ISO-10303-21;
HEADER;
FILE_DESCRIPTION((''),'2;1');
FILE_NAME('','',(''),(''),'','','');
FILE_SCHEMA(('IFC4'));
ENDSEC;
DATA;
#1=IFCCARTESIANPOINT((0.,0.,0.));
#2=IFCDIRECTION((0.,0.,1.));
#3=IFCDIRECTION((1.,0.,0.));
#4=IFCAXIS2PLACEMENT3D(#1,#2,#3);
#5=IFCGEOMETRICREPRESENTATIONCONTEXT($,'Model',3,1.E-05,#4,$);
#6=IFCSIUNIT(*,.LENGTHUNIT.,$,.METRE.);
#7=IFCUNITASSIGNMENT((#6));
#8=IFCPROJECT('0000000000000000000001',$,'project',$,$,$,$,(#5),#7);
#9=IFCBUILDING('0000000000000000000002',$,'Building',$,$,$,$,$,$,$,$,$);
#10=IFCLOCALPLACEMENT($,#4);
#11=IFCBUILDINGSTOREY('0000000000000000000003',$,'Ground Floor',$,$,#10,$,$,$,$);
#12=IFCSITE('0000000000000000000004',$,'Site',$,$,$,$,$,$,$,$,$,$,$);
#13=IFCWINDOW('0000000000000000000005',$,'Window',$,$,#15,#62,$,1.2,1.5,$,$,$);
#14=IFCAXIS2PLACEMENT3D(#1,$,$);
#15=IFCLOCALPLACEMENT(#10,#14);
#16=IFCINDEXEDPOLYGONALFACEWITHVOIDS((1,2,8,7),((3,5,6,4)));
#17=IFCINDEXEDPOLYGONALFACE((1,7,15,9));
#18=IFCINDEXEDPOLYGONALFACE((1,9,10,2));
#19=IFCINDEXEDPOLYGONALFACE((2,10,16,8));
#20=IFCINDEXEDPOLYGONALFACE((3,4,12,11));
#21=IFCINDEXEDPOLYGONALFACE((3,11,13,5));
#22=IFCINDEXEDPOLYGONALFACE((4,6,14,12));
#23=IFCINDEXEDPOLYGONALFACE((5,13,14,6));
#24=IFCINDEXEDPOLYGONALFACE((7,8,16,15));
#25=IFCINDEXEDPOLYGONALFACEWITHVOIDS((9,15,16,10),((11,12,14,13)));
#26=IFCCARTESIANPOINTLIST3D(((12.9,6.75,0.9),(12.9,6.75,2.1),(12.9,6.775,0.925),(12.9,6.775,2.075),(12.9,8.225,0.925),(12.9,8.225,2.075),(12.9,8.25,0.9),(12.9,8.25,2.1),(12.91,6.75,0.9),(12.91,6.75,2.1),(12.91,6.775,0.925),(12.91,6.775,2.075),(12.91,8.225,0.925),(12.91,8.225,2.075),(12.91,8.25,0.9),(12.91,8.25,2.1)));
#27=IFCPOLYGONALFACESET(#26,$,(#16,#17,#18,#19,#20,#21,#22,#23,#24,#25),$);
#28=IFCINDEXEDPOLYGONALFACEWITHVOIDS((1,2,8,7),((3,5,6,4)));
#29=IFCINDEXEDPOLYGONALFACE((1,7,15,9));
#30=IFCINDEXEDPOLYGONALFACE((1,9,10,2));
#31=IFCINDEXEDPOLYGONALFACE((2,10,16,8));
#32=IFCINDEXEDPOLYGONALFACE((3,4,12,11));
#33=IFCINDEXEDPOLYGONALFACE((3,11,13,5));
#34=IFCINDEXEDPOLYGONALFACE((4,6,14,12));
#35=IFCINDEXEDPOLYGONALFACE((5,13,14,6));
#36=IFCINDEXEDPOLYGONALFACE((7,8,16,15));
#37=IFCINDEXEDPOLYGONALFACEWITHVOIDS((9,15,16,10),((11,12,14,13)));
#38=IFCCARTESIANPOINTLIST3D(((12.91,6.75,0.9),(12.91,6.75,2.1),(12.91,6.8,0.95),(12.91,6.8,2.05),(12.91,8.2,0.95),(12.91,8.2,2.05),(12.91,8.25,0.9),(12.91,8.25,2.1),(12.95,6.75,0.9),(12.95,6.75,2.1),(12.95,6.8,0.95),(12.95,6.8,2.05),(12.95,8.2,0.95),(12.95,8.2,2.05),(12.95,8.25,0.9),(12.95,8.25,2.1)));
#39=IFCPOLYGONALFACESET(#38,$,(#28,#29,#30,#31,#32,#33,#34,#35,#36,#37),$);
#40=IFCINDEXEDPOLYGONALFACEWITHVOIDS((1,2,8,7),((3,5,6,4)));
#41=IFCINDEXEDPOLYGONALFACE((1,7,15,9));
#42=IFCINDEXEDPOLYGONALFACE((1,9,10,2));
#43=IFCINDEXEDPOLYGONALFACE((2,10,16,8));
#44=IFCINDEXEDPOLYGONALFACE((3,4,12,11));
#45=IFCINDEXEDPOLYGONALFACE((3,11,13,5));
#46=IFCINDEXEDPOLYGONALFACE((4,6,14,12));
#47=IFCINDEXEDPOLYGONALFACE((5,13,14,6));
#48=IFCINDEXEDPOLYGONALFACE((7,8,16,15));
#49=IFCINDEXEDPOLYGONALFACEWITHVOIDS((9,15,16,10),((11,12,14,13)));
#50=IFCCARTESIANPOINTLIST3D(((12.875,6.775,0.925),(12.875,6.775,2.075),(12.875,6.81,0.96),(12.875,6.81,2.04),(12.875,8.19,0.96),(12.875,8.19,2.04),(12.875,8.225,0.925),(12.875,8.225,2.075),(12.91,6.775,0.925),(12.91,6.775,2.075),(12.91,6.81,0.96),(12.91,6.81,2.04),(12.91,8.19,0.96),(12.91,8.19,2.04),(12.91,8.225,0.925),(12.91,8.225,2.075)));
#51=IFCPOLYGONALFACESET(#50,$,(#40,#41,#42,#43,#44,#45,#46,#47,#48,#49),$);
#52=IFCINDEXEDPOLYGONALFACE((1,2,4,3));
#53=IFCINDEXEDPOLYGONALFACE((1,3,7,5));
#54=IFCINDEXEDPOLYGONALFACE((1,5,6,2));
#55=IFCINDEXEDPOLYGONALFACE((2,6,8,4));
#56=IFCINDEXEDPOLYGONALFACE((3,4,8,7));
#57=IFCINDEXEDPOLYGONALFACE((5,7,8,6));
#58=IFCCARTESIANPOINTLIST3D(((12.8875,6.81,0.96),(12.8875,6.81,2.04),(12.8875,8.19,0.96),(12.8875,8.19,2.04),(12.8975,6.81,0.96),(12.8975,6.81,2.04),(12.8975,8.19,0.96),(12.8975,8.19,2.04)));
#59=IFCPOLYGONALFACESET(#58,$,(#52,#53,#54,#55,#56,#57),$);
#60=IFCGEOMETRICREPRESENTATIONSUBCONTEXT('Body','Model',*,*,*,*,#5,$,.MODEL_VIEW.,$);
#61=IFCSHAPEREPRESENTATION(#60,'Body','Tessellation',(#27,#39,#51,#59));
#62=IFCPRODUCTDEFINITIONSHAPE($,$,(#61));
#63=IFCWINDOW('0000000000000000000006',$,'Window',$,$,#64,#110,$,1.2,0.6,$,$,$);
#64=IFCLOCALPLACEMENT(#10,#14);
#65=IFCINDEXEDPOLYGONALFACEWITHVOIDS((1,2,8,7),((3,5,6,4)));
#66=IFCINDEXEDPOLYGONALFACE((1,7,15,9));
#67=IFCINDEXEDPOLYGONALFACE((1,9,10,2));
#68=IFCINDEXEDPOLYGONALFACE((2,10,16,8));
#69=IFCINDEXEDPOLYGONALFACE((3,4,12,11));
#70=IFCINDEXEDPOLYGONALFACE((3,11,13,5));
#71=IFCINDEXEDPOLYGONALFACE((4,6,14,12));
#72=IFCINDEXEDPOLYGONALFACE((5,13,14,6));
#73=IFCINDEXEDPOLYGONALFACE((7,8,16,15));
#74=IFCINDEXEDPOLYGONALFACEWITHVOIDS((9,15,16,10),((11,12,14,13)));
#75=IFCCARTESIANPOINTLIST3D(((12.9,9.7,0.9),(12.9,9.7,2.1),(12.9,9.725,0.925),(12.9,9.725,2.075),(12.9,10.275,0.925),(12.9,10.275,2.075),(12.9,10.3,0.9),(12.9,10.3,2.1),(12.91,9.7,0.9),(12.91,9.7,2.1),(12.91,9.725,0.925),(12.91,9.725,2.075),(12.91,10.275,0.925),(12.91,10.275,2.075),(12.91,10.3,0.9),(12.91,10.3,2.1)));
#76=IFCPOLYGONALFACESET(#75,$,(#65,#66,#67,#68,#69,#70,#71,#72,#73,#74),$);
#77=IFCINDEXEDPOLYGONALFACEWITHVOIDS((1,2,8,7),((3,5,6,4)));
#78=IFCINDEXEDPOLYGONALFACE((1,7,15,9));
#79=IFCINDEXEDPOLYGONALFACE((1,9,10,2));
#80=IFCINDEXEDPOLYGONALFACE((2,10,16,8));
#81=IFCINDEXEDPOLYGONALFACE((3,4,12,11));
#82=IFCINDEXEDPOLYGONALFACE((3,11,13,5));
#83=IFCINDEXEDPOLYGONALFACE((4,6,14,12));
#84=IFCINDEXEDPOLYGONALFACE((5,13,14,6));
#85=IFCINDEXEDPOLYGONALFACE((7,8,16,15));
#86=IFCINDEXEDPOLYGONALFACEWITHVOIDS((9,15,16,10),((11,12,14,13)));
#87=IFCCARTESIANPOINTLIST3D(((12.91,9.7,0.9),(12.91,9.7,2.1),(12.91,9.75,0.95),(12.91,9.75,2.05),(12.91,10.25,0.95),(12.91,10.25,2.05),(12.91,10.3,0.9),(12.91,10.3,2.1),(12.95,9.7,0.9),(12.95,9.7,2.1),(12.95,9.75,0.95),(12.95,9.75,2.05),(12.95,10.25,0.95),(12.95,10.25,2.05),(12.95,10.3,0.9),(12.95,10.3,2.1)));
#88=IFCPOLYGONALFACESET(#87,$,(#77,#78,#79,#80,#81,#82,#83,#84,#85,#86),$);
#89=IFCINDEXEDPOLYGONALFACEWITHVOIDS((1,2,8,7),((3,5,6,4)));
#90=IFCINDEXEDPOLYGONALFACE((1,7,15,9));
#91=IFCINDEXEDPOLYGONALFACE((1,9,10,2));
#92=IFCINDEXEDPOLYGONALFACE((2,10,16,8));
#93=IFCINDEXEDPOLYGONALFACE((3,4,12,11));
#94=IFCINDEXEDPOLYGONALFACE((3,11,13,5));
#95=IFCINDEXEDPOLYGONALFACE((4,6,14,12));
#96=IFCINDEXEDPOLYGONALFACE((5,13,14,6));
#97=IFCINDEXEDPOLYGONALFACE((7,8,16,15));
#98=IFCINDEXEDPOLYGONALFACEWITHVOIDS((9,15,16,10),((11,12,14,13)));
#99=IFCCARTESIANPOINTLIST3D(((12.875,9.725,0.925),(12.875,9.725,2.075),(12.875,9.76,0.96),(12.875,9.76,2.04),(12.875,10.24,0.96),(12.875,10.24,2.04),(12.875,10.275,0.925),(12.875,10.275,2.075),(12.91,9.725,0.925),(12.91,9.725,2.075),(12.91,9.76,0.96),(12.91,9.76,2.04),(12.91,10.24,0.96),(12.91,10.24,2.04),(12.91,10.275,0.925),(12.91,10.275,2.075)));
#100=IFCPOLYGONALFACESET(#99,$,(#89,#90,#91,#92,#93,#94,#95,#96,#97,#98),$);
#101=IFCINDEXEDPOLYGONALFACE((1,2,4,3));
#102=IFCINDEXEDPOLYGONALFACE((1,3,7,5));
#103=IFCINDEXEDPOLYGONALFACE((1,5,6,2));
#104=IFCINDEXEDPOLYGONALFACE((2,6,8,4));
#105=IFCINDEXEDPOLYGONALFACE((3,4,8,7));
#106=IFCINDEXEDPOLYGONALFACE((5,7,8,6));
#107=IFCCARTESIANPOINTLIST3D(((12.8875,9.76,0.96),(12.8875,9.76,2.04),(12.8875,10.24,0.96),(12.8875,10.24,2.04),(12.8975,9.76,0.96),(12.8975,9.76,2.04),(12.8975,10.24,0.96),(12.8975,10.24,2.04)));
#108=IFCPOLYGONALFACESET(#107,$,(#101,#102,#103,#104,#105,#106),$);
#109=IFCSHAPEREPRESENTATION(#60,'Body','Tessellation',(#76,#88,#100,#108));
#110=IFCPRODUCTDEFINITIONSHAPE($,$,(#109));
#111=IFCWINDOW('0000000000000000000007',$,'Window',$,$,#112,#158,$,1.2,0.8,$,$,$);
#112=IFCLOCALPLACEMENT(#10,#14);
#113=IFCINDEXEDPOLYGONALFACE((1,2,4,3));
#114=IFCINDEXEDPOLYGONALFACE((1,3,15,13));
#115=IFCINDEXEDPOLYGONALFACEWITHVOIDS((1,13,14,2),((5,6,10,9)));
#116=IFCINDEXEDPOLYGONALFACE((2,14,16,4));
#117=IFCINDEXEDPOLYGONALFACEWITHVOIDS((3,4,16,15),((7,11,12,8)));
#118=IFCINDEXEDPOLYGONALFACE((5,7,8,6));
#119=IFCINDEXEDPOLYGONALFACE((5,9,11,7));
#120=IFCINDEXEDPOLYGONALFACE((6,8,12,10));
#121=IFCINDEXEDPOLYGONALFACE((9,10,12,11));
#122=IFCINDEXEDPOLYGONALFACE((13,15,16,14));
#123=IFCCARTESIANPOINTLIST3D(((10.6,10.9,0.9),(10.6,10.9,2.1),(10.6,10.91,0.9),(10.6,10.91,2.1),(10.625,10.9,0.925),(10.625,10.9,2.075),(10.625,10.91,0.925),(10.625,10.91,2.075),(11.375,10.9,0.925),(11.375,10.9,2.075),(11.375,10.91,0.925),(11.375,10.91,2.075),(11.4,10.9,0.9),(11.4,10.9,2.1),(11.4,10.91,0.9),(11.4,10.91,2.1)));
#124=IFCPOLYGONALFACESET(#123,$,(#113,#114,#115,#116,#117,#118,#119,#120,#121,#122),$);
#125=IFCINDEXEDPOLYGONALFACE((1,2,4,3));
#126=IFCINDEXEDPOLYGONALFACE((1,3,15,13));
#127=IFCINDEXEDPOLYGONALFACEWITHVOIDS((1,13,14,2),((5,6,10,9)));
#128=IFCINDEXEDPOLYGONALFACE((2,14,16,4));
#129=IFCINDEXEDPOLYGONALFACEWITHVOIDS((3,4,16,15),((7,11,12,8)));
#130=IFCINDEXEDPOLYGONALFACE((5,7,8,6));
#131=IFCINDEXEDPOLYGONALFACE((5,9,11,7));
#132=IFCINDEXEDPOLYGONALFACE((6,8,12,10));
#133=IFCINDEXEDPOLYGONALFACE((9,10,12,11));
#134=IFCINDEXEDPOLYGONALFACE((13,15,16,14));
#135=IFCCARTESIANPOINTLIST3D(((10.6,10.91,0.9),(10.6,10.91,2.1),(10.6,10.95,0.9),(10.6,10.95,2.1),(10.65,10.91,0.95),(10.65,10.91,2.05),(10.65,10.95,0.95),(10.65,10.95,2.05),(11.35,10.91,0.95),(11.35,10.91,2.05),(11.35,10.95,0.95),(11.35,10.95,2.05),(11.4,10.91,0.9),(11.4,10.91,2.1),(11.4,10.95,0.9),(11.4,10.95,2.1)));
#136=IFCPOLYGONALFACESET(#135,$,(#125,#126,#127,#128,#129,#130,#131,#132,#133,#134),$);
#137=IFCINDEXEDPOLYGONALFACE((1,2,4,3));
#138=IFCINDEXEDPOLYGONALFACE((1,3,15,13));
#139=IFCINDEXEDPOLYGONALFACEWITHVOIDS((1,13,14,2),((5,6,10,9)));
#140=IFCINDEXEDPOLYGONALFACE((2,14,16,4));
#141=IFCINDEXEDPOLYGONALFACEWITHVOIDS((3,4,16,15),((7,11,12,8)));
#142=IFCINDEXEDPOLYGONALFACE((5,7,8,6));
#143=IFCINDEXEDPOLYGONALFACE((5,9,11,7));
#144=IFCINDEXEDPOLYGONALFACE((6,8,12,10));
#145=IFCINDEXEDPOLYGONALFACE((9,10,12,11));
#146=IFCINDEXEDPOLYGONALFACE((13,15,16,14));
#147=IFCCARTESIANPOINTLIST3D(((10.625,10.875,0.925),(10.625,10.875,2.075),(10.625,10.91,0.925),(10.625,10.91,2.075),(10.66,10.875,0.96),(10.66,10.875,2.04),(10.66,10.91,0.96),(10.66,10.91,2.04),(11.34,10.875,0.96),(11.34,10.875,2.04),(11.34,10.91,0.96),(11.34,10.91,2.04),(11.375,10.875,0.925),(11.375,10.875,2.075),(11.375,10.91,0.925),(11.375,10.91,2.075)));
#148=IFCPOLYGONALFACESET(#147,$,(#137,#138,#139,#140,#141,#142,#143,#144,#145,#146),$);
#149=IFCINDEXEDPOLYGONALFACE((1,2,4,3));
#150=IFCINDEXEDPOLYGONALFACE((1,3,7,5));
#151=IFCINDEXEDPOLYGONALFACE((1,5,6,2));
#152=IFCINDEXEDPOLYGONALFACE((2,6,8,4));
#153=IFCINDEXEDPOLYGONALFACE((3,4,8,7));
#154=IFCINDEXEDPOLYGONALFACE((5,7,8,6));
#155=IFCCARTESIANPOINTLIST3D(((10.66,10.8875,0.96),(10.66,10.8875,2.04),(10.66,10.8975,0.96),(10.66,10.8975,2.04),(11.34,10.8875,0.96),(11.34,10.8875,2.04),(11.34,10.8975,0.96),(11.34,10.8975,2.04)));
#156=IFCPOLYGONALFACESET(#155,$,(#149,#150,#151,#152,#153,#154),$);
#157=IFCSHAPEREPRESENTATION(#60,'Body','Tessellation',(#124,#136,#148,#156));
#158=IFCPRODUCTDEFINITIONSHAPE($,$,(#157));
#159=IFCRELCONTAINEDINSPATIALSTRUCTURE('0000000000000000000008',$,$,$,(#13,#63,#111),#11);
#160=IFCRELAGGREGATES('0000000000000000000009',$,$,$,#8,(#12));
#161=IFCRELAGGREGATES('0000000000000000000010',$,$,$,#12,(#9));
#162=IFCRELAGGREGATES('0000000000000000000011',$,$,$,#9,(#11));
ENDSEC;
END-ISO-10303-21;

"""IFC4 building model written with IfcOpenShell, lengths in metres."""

from ifc_helpers import new_model, si_unit, frame, origin_with_axes, place, context, subcontext, project, spatial, line, indexed_curve, outline, extrude, element, save


model = new_model("IFC4")

# Units and contexts
model_context = context("Model", 3, precision=1e-05, world=origin_with_axes())
body_context = subcontext(model_context, "Body", "Model", "MODEL_VIEW")
ifc_project = project(units=[si_unit("LENGTHUNIT", "METRE")], contexts=[model_context])

# Site, building, storey
site = spatial("IfcSite", under=ifc_project, Name="Site")
building = spatial("IfcBuilding", under=site, Name="Building")
storey_placement = place(None, origin_with_axes())
storey = spatial("IfcBuildingStorey", under=building, at=storey_placement, Name="Ground Floor")

# Windows
window_1_placement = place(storey_placement, frame((13.0, 6.75, 0.9), z_axis=(0.0, 0.0, 1.0), x_axis=(0.0, 1.0, 0.0)))
element("IfcWindow", 1, at=window_1_placement, inside=storey, Name="Window", OverallHeight=1.2, OverallWidth=1.5, context=body_context, shape_type="SweptSolid", body=[
    extrude(outline(indexed_curve([(0.0, 0.0), (1.5, 0.0), (1.5, 1.2), (0.0, 1.2)], segments=[line(1, 2, 3, 4, 1)]), holes=[indexed_curve([(0.025, 0.025), (1.475, 0.025), (1.475, 1.175), (0.025, 1.175)], segments=[line(1, 2, 3, 4, 1)])]), frame((0.0, 0.09, 0.0), z_axis=(0.0, -1.0, 0.0), x_axis=(1.0, 0.0, 0.0)), (0.0, 0.0, -1.0), 0.01),
    extrude(outline(indexed_curve([(0.0, 0.0), (1.5, 0.0), (1.5, 1.2), (0.0, 1.2)], segments=[line(1, 2, 3, 4, 1)]), holes=[indexed_curve([(0.05, 0.05), (1.45, 0.05), (1.45, 1.15), (0.05, 1.15)], segments=[line(1, 2, 3, 4, 1)])]), frame((0.0, 0.05, 0.0), z_axis=(0.0, -1.0, 0.0), x_axis=(1.0, 0.0, 0.0)), (0.0, 0.0, -1.0), 0.04),
    extrude(outline(indexed_curve([(0.0, 0.0), (1.45, 0.0), (1.45, 1.15), (0.0, 1.15)], segments=[line(1, 2, 3, 4, 1)]), holes=[indexed_curve([(0.035, 0.035), (1.415, 0.035), (1.415, 1.115), (0.035, 1.115)], segments=[line(1, 2, 3, 4, 1)])]), frame((0.025, 0.09, 0.025), z_axis=(0.0, -1.0, 0.0), x_axis=(1.0, 0.0, 0.0)), (0.0, 0.0, -1.0), 0.035),
    extrude(outline(indexed_curve([(0.035, 0.035), (1.415, 0.035), (1.415, 1.115), (0.035, 1.115)], segments=[line(1, 2, 3, 4, 1)])), frame((0.025, 0.1025, 0.025), z_axis=(0.0, -1.0, 0.0), x_axis=(1.0, 0.0, 0.0)), (0.0, 0.0, -1.0), 0.01),
])
window_2_placement = place(storey_placement, frame((13.0, 9.7, 0.9), z_axis=(0.0, 0.0, 1.0), x_axis=(0.0, 1.0, 0.0)))
element("IfcWindow", 2, at=window_2_placement, inside=storey, Name="Window", OverallHeight=1.2, OverallWidth=0.6, context=body_context, shape_type="SweptSolid", body=[
    extrude(outline(indexed_curve([(0.0, 0.0), (0.6, 0.0), (0.6, 1.2), (0.0, 1.2)], segments=[line(1, 2, 3, 4, 1)]), holes=[indexed_curve([(0.025, 0.025), (0.575, 0.025), (0.575, 1.175), (0.025, 1.175)], segments=[line(1, 2, 3, 4, 1)])]), frame((0.0, 0.09, 0.0), z_axis=(0.0, -1.0, 0.0), x_axis=(1.0, 0.0, 0.0)), (0.0, 0.0, -1.0), 0.01),
    extrude(outline(indexed_curve([(0.0, 0.0), (0.6, 0.0), (0.6, 1.2), (0.0, 1.2)], segments=[line(1, 2, 3, 4, 1)]), holes=[indexed_curve([(0.05, 0.05), (0.55, 0.05), (0.55, 1.15), (0.05, 1.15)], segments=[line(1, 2, 3, 4, 1)])]), frame((0.0, 0.05, 0.0), z_axis=(0.0, -1.0, 0.0), x_axis=(1.0, 0.0, 0.0)), (0.0, 0.0, -1.0), 0.04),
    extrude(outline(indexed_curve([(0.0, 0.0), (0.55, 0.0), (0.55, 1.15), (0.0, 1.15)], segments=[line(1, 2, 3, 4, 1)]), holes=[indexed_curve([(0.035, 0.035), (0.515, 0.035), (0.515, 1.115), (0.035, 1.115)], segments=[line(1, 2, 3, 4, 1)])]), frame((0.025, 0.09, 0.025), z_axis=(0.0, -1.0, 0.0), x_axis=(1.0, 0.0, 0.0)), (0.0, 0.0, -1.0), 0.035),
    extrude(outline(indexed_curve([(0.035, 0.035), (0.515, 0.035), (0.515, 1.115), (0.035, 1.115)], segments=[line(1, 2, 3, 4, 1)])), frame((0.025, 0.1025, 0.025), z_axis=(0.0, -1.0, 0.0), x_axis=(1.0, 0.0, 0.0)), (0.0, 0.0, -1.0), 0.01),
])
window_3_placement = place(storey_placement, frame((11.4, 11.0, 0.9), z_axis=(0.0, 0.0, 1.0), x_axis=(-1.0, 0.0, 0.0)))
element("IfcWindow", 3, at=window_3_placement, inside=storey, Name="Window", OverallHeight=1.2, OverallWidth=0.8, context=body_context, shape_type="SweptSolid", body=[
    extrude(outline(indexed_curve([(0.0, 0.0), (0.8, 0.0), (0.8, 1.2), (0.0, 1.2)], segments=[line(1, 2, 3, 4, 1)]), holes=[indexed_curve([(0.025, 0.025), (0.775, 0.025), (0.775, 1.175), (0.025, 1.175)], segments=[line(1, 2, 3, 4, 1)])]), frame((0.0, 0.09, 0.0), z_axis=(0.0, -1.0, 0.0), x_axis=(1.0, 0.0, 0.0)), (0.0, 0.0, -1.0), 0.01),
    extrude(outline(indexed_curve([(0.0, 0.0), (0.8, 0.0), (0.8, 1.2), (0.0, 1.2)], segments=[line(1, 2, 3, 4, 1)]), holes=[indexed_curve([(0.05, 0.05), (0.75, 0.05), (0.75, 1.15), (0.05, 1.15)], segments=[line(1, 2, 3, 4, 1)])]), frame((0.0, 0.05, 0.0), z_axis=(0.0, -1.0, 0.0), x_axis=(1.0, 0.0, 0.0)), (0.0, 0.0, -1.0), 0.04),
    extrude(outline(indexed_curve([(0.0, 0.0), (0.75, 0.0), (0.75, 1.15), (0.0, 1.15)], segments=[line(1, 2, 3, 4, 1)]), holes=[indexed_curve([(0.035, 0.035), (0.715, 0.035), (0.715, 1.115), (0.035, 1.115)], segments=[line(1, 2, 3, 4, 1)])]), frame((0.025, 0.09, 0.025), z_axis=(0.0, -1.0, 0.0), x_axis=(1.0, 0.0, 0.0)), (0.0, 0.0, -1.0), 0.035),
    extrude(outline(indexed_curve([(0.035, 0.035), (0.715, 0.035), (0.715, 1.115), (0.035, 1.115)], segments=[line(1, 2, 3, 4, 1)])), frame((0.025, 0.1025, 0.025), z_axis=(0.0, -1.0, 0.0), x_axis=(1.0, 0.0, 0.0)), (0.0, 0.0, -1.0), 0.01),
])

save(model, "model.ifc")
